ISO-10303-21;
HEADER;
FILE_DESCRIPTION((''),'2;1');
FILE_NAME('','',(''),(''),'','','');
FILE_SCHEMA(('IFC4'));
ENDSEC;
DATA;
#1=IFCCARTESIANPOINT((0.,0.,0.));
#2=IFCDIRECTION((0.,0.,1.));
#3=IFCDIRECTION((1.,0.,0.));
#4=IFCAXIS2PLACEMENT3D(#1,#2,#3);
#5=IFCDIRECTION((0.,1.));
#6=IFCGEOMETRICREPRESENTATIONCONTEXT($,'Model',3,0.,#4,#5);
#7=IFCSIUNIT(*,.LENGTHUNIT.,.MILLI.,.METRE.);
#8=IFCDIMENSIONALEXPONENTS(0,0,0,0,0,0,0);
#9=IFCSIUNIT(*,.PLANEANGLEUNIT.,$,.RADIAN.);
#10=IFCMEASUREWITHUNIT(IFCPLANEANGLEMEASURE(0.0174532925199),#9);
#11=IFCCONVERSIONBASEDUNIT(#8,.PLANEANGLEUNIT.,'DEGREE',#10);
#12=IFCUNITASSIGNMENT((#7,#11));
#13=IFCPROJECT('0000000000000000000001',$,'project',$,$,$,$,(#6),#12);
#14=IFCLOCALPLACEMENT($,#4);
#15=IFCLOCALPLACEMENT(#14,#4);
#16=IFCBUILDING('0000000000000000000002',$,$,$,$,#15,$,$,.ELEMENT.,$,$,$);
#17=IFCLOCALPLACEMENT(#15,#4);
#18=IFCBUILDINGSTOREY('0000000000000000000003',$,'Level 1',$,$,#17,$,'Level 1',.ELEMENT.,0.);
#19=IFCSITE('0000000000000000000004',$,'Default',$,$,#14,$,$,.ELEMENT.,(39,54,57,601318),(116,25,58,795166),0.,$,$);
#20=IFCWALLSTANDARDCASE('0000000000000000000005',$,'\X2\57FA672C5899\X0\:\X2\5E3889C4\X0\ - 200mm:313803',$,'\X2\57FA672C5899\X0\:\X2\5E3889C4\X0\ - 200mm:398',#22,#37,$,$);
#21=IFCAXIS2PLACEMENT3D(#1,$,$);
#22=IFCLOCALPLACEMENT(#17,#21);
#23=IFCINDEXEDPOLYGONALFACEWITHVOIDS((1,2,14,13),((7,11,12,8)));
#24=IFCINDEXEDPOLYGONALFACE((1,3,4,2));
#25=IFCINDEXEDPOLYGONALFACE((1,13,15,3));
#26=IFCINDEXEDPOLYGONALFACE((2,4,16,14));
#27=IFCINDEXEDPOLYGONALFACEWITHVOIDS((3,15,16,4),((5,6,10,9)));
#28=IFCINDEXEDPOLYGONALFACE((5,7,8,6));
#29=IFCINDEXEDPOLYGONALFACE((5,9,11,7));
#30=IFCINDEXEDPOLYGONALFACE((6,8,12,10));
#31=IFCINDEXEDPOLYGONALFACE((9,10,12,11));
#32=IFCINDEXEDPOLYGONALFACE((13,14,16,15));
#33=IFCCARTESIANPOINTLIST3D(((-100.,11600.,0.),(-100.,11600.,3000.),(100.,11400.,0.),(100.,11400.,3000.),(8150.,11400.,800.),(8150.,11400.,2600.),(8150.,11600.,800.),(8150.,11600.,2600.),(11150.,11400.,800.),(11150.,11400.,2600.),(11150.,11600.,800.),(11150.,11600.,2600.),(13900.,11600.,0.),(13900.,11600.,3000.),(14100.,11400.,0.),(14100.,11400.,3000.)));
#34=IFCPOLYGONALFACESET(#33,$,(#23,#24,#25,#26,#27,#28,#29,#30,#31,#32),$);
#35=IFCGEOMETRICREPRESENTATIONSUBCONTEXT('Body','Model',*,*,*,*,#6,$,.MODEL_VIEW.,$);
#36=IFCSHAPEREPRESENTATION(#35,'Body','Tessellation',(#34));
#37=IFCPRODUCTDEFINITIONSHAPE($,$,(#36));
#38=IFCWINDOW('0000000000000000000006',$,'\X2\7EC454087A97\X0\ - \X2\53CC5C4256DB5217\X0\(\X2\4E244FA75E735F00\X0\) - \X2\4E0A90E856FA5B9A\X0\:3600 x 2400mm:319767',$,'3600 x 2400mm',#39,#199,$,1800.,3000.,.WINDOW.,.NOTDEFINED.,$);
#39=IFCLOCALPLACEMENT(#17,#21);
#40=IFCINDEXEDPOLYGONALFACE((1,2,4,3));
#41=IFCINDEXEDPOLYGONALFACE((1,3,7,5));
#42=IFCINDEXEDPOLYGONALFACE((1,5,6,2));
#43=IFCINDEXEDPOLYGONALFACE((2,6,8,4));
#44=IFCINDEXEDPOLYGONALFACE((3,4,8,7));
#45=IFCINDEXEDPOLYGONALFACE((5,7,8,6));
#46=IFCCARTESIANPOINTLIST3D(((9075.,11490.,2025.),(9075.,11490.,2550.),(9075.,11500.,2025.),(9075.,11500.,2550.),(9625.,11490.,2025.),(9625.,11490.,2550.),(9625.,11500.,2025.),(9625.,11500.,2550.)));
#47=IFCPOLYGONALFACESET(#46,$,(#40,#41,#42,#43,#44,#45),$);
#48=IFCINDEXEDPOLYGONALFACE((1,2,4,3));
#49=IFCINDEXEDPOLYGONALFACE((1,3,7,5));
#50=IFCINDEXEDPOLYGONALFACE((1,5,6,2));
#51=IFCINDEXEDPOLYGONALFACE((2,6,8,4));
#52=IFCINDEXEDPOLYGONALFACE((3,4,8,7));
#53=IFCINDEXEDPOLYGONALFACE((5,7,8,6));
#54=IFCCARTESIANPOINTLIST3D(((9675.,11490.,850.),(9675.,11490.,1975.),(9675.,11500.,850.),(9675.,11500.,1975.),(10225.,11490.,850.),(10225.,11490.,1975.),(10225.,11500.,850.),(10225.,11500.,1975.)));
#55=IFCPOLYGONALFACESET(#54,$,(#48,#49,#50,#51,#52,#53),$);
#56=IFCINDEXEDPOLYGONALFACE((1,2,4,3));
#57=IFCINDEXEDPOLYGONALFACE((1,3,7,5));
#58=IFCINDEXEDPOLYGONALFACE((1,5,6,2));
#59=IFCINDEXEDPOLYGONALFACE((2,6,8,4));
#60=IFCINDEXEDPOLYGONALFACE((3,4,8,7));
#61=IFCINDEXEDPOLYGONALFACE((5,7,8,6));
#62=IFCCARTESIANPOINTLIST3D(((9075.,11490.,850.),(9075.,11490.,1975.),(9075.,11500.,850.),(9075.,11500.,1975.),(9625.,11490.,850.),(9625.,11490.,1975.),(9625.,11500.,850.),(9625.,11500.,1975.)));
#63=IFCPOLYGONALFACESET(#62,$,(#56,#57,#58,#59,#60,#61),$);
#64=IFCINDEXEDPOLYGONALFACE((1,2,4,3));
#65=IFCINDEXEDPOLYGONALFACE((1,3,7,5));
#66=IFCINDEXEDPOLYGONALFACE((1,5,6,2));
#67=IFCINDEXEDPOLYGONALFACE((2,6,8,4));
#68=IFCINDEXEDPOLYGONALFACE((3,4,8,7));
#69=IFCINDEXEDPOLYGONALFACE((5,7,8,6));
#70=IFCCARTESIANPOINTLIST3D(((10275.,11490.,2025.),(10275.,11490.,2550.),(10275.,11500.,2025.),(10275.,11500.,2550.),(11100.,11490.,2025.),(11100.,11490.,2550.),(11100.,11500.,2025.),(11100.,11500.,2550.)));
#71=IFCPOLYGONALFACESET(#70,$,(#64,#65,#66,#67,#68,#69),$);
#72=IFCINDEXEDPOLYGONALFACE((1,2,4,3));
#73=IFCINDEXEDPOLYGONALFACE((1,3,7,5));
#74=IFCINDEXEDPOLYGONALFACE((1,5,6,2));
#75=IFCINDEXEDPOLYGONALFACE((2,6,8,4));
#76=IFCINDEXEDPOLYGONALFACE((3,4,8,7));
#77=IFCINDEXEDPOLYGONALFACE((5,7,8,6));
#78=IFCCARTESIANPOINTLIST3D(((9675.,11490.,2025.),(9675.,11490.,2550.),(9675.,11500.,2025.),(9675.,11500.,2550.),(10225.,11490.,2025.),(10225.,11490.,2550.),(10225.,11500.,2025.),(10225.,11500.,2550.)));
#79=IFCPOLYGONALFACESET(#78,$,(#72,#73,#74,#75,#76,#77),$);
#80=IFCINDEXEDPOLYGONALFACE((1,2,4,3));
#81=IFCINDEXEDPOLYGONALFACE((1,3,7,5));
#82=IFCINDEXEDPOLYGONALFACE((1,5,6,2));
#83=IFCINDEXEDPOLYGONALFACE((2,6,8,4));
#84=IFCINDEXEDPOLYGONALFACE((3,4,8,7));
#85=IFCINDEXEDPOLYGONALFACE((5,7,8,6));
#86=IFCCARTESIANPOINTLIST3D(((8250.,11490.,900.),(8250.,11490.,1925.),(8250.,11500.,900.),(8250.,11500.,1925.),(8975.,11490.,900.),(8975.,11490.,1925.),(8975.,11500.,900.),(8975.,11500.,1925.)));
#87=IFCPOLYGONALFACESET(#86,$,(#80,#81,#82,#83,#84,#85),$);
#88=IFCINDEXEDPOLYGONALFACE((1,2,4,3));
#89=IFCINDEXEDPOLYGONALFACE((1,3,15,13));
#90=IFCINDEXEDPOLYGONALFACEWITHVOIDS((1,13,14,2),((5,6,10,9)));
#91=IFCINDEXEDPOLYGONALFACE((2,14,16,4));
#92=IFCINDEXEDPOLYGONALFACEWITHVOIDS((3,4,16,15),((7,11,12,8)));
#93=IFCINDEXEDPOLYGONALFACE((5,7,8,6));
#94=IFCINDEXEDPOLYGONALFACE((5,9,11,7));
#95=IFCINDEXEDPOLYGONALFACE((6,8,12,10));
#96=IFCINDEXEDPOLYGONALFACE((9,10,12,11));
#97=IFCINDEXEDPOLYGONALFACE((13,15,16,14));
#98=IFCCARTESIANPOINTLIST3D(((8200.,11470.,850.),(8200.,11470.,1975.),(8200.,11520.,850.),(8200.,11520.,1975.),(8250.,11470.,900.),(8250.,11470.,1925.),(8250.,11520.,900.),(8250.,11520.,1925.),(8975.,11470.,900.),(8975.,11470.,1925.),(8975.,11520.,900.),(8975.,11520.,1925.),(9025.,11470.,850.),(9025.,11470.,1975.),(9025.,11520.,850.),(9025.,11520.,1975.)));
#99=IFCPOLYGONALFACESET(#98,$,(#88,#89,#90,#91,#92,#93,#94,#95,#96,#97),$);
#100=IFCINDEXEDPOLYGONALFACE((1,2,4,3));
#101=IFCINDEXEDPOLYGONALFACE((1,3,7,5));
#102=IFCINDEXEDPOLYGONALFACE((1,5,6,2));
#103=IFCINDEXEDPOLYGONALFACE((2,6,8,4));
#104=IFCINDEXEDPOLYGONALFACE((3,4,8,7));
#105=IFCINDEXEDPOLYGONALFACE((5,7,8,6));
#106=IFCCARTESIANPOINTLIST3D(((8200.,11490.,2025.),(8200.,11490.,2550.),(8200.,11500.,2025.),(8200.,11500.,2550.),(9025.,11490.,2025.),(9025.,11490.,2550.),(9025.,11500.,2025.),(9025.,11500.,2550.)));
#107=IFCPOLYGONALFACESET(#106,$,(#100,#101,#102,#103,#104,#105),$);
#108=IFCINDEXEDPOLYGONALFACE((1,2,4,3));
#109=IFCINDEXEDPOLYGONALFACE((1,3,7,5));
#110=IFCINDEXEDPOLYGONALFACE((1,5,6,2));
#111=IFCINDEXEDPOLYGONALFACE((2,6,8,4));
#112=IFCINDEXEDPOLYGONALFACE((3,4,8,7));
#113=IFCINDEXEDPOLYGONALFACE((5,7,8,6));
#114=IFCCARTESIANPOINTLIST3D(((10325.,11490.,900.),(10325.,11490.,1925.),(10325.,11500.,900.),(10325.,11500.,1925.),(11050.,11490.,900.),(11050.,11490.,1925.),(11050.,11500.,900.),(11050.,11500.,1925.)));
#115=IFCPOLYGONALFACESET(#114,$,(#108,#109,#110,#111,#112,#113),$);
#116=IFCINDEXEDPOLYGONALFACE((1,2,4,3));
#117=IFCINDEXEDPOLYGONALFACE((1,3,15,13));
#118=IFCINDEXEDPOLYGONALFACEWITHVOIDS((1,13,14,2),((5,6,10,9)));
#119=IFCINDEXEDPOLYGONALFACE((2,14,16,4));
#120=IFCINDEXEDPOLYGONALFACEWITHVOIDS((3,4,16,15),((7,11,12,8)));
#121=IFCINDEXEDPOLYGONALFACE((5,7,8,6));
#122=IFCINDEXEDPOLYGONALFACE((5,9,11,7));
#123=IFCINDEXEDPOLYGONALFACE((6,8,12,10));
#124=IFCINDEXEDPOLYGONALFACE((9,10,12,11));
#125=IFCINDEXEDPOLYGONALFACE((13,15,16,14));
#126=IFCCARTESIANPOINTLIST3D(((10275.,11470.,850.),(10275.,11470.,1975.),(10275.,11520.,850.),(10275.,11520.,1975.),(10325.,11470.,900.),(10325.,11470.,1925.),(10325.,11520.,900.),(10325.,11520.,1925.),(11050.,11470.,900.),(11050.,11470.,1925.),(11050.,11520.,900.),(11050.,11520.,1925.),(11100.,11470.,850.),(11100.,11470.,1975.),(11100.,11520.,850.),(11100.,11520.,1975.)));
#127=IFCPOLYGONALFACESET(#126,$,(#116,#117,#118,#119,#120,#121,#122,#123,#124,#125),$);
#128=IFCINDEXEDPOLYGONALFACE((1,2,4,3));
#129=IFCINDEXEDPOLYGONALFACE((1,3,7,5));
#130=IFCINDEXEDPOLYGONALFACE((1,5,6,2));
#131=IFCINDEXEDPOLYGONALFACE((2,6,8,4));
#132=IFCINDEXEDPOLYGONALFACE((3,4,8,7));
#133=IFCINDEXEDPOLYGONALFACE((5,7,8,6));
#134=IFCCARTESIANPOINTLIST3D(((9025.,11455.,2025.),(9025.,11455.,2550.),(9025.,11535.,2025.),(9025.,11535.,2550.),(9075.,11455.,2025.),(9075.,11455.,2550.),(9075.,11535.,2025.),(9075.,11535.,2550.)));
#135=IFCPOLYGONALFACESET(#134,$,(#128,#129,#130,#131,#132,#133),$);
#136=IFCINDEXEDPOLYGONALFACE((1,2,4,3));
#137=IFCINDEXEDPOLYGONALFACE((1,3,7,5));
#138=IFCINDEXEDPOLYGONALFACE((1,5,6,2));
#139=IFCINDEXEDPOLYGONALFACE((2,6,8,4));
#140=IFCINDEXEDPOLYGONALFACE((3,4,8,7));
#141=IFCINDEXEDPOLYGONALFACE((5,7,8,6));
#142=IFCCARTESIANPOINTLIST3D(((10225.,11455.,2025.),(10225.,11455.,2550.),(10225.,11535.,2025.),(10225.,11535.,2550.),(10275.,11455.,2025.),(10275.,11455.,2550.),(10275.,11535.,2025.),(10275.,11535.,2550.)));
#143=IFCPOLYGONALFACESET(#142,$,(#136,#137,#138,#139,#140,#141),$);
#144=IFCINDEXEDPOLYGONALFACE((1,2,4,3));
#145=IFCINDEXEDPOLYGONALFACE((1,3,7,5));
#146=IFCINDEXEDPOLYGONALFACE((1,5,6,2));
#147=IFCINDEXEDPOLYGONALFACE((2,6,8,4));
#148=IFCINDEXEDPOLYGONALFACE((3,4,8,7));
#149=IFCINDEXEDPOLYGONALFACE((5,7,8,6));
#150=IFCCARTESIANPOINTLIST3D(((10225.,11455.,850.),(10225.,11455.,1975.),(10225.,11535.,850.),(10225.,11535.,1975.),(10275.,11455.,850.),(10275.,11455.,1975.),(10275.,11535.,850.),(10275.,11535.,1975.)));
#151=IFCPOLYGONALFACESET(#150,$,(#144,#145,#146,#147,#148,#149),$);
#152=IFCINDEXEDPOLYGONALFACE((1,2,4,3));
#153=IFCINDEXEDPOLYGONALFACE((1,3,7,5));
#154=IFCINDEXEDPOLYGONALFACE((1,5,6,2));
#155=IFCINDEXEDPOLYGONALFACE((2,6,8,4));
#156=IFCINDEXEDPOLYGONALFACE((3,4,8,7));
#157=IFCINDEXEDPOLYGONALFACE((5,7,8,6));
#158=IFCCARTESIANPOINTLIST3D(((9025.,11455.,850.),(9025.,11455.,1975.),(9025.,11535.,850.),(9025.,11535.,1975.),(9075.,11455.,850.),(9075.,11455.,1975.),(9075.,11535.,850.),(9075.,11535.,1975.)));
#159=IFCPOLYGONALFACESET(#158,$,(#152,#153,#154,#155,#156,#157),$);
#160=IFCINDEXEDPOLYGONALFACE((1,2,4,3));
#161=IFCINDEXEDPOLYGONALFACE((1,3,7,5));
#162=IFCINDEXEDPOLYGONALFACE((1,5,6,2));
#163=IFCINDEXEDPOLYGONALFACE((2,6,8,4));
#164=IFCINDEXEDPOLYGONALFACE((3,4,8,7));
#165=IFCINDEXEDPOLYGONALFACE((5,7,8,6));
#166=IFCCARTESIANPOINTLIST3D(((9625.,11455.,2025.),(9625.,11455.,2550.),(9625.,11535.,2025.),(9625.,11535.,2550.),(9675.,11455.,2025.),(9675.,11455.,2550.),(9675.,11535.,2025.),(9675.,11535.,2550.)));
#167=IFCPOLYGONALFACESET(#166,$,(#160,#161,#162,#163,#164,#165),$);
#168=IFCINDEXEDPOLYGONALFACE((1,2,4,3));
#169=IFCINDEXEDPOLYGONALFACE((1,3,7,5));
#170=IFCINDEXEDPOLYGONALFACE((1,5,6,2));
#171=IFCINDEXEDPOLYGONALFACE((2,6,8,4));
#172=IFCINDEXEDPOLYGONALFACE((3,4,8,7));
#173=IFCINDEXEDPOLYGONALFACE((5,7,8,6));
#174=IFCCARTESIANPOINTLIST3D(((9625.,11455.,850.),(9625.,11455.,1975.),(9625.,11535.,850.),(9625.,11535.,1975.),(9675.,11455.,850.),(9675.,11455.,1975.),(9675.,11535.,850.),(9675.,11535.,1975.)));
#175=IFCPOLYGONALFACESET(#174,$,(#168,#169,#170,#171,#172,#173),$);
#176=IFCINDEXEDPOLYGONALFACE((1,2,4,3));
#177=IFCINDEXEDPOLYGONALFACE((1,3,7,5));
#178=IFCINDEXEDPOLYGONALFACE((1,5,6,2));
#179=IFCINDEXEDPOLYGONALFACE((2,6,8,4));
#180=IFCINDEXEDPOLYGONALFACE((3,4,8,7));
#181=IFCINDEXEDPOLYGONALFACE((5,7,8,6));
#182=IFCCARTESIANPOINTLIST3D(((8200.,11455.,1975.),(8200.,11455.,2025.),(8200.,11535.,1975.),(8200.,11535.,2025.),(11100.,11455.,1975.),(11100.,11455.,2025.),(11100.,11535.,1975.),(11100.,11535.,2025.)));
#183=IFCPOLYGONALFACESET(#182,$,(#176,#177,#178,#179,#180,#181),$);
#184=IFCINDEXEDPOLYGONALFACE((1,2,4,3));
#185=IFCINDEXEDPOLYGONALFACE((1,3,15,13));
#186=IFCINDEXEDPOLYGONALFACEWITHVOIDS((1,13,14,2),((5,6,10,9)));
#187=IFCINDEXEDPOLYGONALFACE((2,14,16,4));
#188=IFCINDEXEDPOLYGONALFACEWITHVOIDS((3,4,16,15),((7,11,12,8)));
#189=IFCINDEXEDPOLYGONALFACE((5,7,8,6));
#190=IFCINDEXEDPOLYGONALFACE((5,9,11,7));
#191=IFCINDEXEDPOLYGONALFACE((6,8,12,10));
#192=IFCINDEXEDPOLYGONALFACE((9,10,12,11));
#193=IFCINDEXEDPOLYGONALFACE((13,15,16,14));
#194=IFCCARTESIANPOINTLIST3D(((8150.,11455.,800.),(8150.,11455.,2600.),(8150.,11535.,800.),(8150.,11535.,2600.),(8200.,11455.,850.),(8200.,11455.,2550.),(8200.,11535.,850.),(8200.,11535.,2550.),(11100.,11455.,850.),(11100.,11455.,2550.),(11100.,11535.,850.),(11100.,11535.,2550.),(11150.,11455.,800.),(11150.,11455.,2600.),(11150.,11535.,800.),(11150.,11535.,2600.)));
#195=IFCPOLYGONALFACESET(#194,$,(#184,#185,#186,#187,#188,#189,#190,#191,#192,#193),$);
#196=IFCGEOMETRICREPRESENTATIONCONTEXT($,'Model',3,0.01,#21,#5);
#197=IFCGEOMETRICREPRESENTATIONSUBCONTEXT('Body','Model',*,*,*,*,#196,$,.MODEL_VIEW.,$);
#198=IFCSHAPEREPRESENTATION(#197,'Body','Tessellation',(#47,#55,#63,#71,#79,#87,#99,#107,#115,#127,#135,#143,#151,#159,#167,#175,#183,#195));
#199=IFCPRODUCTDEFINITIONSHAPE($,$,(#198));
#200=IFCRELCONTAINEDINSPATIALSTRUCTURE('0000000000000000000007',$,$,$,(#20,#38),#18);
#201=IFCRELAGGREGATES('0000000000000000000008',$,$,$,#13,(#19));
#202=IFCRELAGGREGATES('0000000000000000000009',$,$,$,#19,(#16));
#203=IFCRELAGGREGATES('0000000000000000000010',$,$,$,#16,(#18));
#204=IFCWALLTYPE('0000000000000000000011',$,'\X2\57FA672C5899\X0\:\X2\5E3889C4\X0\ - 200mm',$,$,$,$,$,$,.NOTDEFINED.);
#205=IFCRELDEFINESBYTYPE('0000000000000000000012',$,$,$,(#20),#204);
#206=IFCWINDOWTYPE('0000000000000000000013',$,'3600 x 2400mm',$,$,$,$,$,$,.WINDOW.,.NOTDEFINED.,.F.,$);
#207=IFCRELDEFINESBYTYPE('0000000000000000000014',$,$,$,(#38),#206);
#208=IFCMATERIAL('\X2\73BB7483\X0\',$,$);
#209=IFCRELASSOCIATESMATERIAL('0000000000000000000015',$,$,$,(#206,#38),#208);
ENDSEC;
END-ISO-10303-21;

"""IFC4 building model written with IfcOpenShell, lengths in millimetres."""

from ifc_helpers import new_model, entity, si_unit, converted_unit, direction, frame, frame_2d, origin, origin_with_axes, origin_2d_with_axis, place, context, subcontext, project, spatial, polyline, rectangle, outline, extrude, source, transform, mapped, material, type_object, type_shapes, element, fill, save


model = new_model("IFC4")

# Units and contexts
model_context_1 = context("Model", 3, precision=0.0, world=origin_with_axes(), true_north=direction((0.0, 1.0)))
model_context_2 = context("Model", 3, precision=0.01, world=origin(), true_north=direction((0.0, 1.0)))
body_context_1 = subcontext(model_context_1, "Body", "Model", "MODEL_VIEW")
body_context_2 = subcontext(model_context_2, "Body", "Model", "MODEL_VIEW")
ifc_project = project(units=[si_unit("LENGTHUNIT", "METRE", prefix="MILLI"), converted_unit("PLANEANGLEUNIT", "DEGREE", entity("IfcPlaneAngleMeasure", 0.0174532925199), si_unit("PLANEANGLEUNIT", "RADIAN"), dimensions=[0, 0, 0, 0, 0, 0, 0])], contexts=[model_context_1])

# Site, building, storey
site_placement = place(None, origin_with_axes())
site = spatial("IfcSite", under=ifc_project, at=site_placement, Name="Default", CompositionType="ELEMENT", RefLatitude=(39, 54, 57, 601318), RefLongitude=(116, 25, 58, 795166), RefElevation=0.0)
building_placement = place(site_placement, origin_with_axes())
building = spatial("IfcBuilding", under=site, at=building_placement, CompositionType="ELEMENT")
storey_placement = place(building_placement, origin_with_axes())
storey = spatial("IfcBuildingStorey", under=building, at=storey_placement, Name="Level 1", LongName="Level 1", CompositionType="ELEMENT", Elevation=0.0)

# Shared definitions
wall_type_1 = type_object("IfcWallType", Name="基本墙:常规 - 200mm", PredefinedType="NOTDEFINED")
placement_1 = place(None, origin())
placement_2 = place(placement_1, origin())
placement_3 = place(placement_2, origin())
ifc_material_1 = material(Name="玻璃")
window_type_1 = type_object("IfcWindowType", Name="3600 x 2400mm", ParameterTakesPrecedence=False, PartitioningType="NOTDEFINED", PredefinedType="WINDOW", material=ifc_material_1)
shared_shape_1 = source(origin(), body_context_2, "Body", "SweptSolid", [
    extrude(rectangle(XDim=10.0, YDim=550.0, at=origin_2d_with_axis()), frame((1200.0, 95.0, 1225.0), z_axis=(0.0, 0.0, 1.0), x_axis=(0.0, 1.0, 0.0)), (0.0, 0.0, 1.0), 525.0),
    extrude(rectangle(XDim=10.0, YDim=550.0, at=origin_2d_with_axis()), frame((1800.0, 95.0, 50.0), z_axis=(0.0, 0.0, 1.0), x_axis=(0.0, 1.0, 0.0)), (0.0, 0.0, 1.0), 1125.0),
    extrude(rectangle(XDim=10.0, YDim=550.0, at=origin_2d_with_axis()), frame((1200.0, 95.0, 50.0), z_axis=(0.0, 0.0, 1.0), x_axis=(0.0, 1.0, 0.0)), (0.0, 0.0, 1.0), 1125.0),
    extrude(rectangle(XDim=10.0, YDim=825.0, at=origin_2d_with_axis()), frame((2537.5, 95.0, 1225.0), z_axis=(0.0, 0.0, 1.0), x_axis=(0.0, 1.0, 0.0)), (0.0, 0.0, 1.0), 525.0),
    extrude(rectangle(XDim=10.0, YDim=550.0, at=origin_2d_with_axis()), frame((1800.0, 95.0, 1225.0), z_axis=(0.0, 0.0, 1.0), x_axis=(0.0, 1.0, 0.0)), (0.0, 0.0, 1.0), 525.0),
    extrude(rectangle(XDim=10.0, YDim=725.0, at=origin_2d_with_axis()), frame((462.5, 95.0, 100.0), z_axis=(0.0, 0.0, 1.0), x_axis=(0.0, 1.0, 0.0)), (0.0, 0.0, 1.0), 1025.0),
    extrude(outline(polyline([(-562.5, -412.5), (562.5, -412.5), (562.5, 412.5), (-562.5, 412.5), (-562.5, -412.5)]), holes=[polyline([(512.5, -362.5), (-512.5, -362.5), (-512.5, 362.5), (512.5, 362.5), (512.5, -362.5)])]), frame((462.5, 70.0, 612.5), z_axis=(0.0, 1.0, 0.0), x_axis=(0.0, 0.0, -1.0)), (0.0, 0.0, 1.0), 50.0),
    extrude(rectangle(XDim=10.0, YDim=825.0, at=origin_2d_with_axis()), frame((462.5, 95.0, 1225.0), z_axis=(0.0, 0.0, 1.0), x_axis=(0.0, 1.0, 0.0)), (0.0, 0.0, 1.0), 525.0),
    extrude(rectangle(XDim=10.0, YDim=725.0, at=origin_2d_with_axis()), frame((2537.5, 95.0, 100.0), z_axis=(0.0, 0.0, 1.0), x_axis=(0.0, 1.0, 0.0)), (0.0, 0.0, 1.0), 1025.0),
    extrude(outline(polyline([(-562.5, -412.5), (562.5, -412.5), (562.5, 412.5), (-562.5, 412.5), (-562.5, -412.5)]), holes=[polyline([(512.5, -362.5), (-512.5, -362.5), (-512.5, 362.5), (512.5, 362.5), (512.5, -362.5)])]), frame((2537.5, 70.0, 612.5), z_axis=(0.0, 1.0, 0.0), x_axis=(0.0, 0.0, -1.0)), (0.0, 0.0, 1.0), 50.0),
    extrude(rectangle(XDim=80.0, YDim=50.0, at=origin_2d_with_axis()), frame((900.0, 95.0, 1225.0), z_axis=(0.0, 0.0, 1.0), x_axis=(0.0, -1.0, 0.0)), (0.0, 0.0, 1.0), 525.0),
    extrude(rectangle(XDim=80.0, YDim=50.0, at=origin_2d_with_axis()), frame((2100.0, 95.0, 1225.0), z_axis=(0.0, 0.0, 1.0), x_axis=(0.0, -1.0, 0.0)), (0.0, 0.0, 1.0), 525.0),
    extrude(rectangle(XDim=80.0, YDim=50.0, at=origin_2d_with_axis()), frame((2100.0, 95.0, 50.0), z_axis=(0.0, 0.0, 1.0), x_axis=(0.0, -1.0, 0.0)), (0.0, 0.0, 1.0), 1125.0),
    extrude(rectangle(XDim=80.0, YDim=50.0, at=origin_2d_with_axis()), frame((900.0, 95.0, 50.0), z_axis=(0.0, 0.0, 1.0), x_axis=(0.0, -1.0, 0.0)), (0.0, 0.0, 1.0), 1125.0),
    extrude(rectangle(XDim=80.0, YDim=50.0, at=origin_2d_with_axis()), frame((1500.0, 95.0, 1225.0), z_axis=(0.0, 0.0, 1.0), x_axis=(0.0, -1.0, 0.0)), (0.0, 0.0, 1.0), 525.0),
    extrude(rectangle(XDim=80.0, YDim=50.0, at=origin_2d_with_axis()), frame((1500.0, 95.0, 50.0), z_axis=(0.0, 0.0, 1.0), x_axis=(0.0, -1.0, 0.0)), (0.0, 0.0, 1.0), 1125.0),
    extrude(rectangle(XDim=80.0, YDim=2900.0, at=origin_2d_with_axis()), frame((1500.0, 95.0, 1175.0), z_axis=(0.0, 0.0, 1.0), x_axis=(0.0, -1.0, 0.0)), (0.0, 0.0, 1.0), 50.0),
    extrude(outline(polyline([(-1500.0, -900.0), (1500.0, -900.0), (1500.0, 900.0), (-1500.0, 900.0), (-1500.0, -900.0)]), holes=[polyline([(1450.0, -850.0), (-1450.0, -850.0), (-1450.0, 850.0), (1450.0, 850.0), (1450.0, -850.0)])]), frame((1500.0, 55.0, 900.0), z_axis=(0.0, 1.0, 0.0), x_axis=(1.0, 0.0, 0.0)), (0.0, 0.0, 1.0), 80.0),
])
type_shapes(window_type_1, [shared_shape_1])

# Wall, opening, window
wall_1_placement = place(storey_placement, frame((0.0, 11500.0, 0.0), z_axis=(0.0, 0.0, 1.0), x_axis=(1.0, 0.0, 0.0)))
wall_1 = element("IfcWallStandardCase", 1, at=wall_1_placement, inside=storey, type_object=wall_type_1, Name="基本墙:常规 - 200mm:313803", ObjectType="基本墙:常规 - 200mm:398", context=body_context_1, shape_type="SweptSolid", body=[
    extrude(outline(polyline([(100.0, -100.0), (14100.0, -100.0), (13900.0, 100.0), (-100.0, 100.0), (100.0, -100.0)])), origin_with_axes(), (0.0, 0.0, 1.0), 3000.0),
])
placement_4 = place(placement_3, frame((100.0, 11500.0, 0.0)))
opening_1_placement = place(placement_4, frame((8050.0, -100.0, 800.0)))
opening_1 = element("IfcOpeningElement", 2, at=opening_1_placement, cuts=wall_1, ObjectType="Opening", PredefinedType="OPENING", context=body_context_2, shape_type="SweptSolid", body=[
    extrude(rectangle(XDim=1800.0, YDim=3000.0, at=frame_2d((900.0, 1500.0), x_axis=(1.0, 0.0))), frame((0.0, 0.0, 0.0), z_axis=(0.0, 1.0, 0.0), x_axis=(0.0, 0.0, 1.0)), (0.0, 0.0, 1.0), 200.0),
])
window_1_placement = place(opening_1_placement, origin())
window_1 = element("IfcWindow", 3, at=window_1_placement, inside=storey, type_object=window_type_1, material=ifc_material_1, Name="组合窗 - 双层四列(两侧平开) - 上部固定:3600 x 2400mm:319767", ObjectType="3600 x 2400mm", OverallHeight=1800.0, OverallWidth=3000.0, PartitioningType="NOTDEFINED", PredefinedType="WINDOW", context=body_context_2, shape_type="MappedRepresentation", body=[
    mapped(shared_shape_1, transform((0.0, 0.0, 0.0), scale=1.0)),
])
fill(opening_1, window_1)

save(model, "model.ifc")
